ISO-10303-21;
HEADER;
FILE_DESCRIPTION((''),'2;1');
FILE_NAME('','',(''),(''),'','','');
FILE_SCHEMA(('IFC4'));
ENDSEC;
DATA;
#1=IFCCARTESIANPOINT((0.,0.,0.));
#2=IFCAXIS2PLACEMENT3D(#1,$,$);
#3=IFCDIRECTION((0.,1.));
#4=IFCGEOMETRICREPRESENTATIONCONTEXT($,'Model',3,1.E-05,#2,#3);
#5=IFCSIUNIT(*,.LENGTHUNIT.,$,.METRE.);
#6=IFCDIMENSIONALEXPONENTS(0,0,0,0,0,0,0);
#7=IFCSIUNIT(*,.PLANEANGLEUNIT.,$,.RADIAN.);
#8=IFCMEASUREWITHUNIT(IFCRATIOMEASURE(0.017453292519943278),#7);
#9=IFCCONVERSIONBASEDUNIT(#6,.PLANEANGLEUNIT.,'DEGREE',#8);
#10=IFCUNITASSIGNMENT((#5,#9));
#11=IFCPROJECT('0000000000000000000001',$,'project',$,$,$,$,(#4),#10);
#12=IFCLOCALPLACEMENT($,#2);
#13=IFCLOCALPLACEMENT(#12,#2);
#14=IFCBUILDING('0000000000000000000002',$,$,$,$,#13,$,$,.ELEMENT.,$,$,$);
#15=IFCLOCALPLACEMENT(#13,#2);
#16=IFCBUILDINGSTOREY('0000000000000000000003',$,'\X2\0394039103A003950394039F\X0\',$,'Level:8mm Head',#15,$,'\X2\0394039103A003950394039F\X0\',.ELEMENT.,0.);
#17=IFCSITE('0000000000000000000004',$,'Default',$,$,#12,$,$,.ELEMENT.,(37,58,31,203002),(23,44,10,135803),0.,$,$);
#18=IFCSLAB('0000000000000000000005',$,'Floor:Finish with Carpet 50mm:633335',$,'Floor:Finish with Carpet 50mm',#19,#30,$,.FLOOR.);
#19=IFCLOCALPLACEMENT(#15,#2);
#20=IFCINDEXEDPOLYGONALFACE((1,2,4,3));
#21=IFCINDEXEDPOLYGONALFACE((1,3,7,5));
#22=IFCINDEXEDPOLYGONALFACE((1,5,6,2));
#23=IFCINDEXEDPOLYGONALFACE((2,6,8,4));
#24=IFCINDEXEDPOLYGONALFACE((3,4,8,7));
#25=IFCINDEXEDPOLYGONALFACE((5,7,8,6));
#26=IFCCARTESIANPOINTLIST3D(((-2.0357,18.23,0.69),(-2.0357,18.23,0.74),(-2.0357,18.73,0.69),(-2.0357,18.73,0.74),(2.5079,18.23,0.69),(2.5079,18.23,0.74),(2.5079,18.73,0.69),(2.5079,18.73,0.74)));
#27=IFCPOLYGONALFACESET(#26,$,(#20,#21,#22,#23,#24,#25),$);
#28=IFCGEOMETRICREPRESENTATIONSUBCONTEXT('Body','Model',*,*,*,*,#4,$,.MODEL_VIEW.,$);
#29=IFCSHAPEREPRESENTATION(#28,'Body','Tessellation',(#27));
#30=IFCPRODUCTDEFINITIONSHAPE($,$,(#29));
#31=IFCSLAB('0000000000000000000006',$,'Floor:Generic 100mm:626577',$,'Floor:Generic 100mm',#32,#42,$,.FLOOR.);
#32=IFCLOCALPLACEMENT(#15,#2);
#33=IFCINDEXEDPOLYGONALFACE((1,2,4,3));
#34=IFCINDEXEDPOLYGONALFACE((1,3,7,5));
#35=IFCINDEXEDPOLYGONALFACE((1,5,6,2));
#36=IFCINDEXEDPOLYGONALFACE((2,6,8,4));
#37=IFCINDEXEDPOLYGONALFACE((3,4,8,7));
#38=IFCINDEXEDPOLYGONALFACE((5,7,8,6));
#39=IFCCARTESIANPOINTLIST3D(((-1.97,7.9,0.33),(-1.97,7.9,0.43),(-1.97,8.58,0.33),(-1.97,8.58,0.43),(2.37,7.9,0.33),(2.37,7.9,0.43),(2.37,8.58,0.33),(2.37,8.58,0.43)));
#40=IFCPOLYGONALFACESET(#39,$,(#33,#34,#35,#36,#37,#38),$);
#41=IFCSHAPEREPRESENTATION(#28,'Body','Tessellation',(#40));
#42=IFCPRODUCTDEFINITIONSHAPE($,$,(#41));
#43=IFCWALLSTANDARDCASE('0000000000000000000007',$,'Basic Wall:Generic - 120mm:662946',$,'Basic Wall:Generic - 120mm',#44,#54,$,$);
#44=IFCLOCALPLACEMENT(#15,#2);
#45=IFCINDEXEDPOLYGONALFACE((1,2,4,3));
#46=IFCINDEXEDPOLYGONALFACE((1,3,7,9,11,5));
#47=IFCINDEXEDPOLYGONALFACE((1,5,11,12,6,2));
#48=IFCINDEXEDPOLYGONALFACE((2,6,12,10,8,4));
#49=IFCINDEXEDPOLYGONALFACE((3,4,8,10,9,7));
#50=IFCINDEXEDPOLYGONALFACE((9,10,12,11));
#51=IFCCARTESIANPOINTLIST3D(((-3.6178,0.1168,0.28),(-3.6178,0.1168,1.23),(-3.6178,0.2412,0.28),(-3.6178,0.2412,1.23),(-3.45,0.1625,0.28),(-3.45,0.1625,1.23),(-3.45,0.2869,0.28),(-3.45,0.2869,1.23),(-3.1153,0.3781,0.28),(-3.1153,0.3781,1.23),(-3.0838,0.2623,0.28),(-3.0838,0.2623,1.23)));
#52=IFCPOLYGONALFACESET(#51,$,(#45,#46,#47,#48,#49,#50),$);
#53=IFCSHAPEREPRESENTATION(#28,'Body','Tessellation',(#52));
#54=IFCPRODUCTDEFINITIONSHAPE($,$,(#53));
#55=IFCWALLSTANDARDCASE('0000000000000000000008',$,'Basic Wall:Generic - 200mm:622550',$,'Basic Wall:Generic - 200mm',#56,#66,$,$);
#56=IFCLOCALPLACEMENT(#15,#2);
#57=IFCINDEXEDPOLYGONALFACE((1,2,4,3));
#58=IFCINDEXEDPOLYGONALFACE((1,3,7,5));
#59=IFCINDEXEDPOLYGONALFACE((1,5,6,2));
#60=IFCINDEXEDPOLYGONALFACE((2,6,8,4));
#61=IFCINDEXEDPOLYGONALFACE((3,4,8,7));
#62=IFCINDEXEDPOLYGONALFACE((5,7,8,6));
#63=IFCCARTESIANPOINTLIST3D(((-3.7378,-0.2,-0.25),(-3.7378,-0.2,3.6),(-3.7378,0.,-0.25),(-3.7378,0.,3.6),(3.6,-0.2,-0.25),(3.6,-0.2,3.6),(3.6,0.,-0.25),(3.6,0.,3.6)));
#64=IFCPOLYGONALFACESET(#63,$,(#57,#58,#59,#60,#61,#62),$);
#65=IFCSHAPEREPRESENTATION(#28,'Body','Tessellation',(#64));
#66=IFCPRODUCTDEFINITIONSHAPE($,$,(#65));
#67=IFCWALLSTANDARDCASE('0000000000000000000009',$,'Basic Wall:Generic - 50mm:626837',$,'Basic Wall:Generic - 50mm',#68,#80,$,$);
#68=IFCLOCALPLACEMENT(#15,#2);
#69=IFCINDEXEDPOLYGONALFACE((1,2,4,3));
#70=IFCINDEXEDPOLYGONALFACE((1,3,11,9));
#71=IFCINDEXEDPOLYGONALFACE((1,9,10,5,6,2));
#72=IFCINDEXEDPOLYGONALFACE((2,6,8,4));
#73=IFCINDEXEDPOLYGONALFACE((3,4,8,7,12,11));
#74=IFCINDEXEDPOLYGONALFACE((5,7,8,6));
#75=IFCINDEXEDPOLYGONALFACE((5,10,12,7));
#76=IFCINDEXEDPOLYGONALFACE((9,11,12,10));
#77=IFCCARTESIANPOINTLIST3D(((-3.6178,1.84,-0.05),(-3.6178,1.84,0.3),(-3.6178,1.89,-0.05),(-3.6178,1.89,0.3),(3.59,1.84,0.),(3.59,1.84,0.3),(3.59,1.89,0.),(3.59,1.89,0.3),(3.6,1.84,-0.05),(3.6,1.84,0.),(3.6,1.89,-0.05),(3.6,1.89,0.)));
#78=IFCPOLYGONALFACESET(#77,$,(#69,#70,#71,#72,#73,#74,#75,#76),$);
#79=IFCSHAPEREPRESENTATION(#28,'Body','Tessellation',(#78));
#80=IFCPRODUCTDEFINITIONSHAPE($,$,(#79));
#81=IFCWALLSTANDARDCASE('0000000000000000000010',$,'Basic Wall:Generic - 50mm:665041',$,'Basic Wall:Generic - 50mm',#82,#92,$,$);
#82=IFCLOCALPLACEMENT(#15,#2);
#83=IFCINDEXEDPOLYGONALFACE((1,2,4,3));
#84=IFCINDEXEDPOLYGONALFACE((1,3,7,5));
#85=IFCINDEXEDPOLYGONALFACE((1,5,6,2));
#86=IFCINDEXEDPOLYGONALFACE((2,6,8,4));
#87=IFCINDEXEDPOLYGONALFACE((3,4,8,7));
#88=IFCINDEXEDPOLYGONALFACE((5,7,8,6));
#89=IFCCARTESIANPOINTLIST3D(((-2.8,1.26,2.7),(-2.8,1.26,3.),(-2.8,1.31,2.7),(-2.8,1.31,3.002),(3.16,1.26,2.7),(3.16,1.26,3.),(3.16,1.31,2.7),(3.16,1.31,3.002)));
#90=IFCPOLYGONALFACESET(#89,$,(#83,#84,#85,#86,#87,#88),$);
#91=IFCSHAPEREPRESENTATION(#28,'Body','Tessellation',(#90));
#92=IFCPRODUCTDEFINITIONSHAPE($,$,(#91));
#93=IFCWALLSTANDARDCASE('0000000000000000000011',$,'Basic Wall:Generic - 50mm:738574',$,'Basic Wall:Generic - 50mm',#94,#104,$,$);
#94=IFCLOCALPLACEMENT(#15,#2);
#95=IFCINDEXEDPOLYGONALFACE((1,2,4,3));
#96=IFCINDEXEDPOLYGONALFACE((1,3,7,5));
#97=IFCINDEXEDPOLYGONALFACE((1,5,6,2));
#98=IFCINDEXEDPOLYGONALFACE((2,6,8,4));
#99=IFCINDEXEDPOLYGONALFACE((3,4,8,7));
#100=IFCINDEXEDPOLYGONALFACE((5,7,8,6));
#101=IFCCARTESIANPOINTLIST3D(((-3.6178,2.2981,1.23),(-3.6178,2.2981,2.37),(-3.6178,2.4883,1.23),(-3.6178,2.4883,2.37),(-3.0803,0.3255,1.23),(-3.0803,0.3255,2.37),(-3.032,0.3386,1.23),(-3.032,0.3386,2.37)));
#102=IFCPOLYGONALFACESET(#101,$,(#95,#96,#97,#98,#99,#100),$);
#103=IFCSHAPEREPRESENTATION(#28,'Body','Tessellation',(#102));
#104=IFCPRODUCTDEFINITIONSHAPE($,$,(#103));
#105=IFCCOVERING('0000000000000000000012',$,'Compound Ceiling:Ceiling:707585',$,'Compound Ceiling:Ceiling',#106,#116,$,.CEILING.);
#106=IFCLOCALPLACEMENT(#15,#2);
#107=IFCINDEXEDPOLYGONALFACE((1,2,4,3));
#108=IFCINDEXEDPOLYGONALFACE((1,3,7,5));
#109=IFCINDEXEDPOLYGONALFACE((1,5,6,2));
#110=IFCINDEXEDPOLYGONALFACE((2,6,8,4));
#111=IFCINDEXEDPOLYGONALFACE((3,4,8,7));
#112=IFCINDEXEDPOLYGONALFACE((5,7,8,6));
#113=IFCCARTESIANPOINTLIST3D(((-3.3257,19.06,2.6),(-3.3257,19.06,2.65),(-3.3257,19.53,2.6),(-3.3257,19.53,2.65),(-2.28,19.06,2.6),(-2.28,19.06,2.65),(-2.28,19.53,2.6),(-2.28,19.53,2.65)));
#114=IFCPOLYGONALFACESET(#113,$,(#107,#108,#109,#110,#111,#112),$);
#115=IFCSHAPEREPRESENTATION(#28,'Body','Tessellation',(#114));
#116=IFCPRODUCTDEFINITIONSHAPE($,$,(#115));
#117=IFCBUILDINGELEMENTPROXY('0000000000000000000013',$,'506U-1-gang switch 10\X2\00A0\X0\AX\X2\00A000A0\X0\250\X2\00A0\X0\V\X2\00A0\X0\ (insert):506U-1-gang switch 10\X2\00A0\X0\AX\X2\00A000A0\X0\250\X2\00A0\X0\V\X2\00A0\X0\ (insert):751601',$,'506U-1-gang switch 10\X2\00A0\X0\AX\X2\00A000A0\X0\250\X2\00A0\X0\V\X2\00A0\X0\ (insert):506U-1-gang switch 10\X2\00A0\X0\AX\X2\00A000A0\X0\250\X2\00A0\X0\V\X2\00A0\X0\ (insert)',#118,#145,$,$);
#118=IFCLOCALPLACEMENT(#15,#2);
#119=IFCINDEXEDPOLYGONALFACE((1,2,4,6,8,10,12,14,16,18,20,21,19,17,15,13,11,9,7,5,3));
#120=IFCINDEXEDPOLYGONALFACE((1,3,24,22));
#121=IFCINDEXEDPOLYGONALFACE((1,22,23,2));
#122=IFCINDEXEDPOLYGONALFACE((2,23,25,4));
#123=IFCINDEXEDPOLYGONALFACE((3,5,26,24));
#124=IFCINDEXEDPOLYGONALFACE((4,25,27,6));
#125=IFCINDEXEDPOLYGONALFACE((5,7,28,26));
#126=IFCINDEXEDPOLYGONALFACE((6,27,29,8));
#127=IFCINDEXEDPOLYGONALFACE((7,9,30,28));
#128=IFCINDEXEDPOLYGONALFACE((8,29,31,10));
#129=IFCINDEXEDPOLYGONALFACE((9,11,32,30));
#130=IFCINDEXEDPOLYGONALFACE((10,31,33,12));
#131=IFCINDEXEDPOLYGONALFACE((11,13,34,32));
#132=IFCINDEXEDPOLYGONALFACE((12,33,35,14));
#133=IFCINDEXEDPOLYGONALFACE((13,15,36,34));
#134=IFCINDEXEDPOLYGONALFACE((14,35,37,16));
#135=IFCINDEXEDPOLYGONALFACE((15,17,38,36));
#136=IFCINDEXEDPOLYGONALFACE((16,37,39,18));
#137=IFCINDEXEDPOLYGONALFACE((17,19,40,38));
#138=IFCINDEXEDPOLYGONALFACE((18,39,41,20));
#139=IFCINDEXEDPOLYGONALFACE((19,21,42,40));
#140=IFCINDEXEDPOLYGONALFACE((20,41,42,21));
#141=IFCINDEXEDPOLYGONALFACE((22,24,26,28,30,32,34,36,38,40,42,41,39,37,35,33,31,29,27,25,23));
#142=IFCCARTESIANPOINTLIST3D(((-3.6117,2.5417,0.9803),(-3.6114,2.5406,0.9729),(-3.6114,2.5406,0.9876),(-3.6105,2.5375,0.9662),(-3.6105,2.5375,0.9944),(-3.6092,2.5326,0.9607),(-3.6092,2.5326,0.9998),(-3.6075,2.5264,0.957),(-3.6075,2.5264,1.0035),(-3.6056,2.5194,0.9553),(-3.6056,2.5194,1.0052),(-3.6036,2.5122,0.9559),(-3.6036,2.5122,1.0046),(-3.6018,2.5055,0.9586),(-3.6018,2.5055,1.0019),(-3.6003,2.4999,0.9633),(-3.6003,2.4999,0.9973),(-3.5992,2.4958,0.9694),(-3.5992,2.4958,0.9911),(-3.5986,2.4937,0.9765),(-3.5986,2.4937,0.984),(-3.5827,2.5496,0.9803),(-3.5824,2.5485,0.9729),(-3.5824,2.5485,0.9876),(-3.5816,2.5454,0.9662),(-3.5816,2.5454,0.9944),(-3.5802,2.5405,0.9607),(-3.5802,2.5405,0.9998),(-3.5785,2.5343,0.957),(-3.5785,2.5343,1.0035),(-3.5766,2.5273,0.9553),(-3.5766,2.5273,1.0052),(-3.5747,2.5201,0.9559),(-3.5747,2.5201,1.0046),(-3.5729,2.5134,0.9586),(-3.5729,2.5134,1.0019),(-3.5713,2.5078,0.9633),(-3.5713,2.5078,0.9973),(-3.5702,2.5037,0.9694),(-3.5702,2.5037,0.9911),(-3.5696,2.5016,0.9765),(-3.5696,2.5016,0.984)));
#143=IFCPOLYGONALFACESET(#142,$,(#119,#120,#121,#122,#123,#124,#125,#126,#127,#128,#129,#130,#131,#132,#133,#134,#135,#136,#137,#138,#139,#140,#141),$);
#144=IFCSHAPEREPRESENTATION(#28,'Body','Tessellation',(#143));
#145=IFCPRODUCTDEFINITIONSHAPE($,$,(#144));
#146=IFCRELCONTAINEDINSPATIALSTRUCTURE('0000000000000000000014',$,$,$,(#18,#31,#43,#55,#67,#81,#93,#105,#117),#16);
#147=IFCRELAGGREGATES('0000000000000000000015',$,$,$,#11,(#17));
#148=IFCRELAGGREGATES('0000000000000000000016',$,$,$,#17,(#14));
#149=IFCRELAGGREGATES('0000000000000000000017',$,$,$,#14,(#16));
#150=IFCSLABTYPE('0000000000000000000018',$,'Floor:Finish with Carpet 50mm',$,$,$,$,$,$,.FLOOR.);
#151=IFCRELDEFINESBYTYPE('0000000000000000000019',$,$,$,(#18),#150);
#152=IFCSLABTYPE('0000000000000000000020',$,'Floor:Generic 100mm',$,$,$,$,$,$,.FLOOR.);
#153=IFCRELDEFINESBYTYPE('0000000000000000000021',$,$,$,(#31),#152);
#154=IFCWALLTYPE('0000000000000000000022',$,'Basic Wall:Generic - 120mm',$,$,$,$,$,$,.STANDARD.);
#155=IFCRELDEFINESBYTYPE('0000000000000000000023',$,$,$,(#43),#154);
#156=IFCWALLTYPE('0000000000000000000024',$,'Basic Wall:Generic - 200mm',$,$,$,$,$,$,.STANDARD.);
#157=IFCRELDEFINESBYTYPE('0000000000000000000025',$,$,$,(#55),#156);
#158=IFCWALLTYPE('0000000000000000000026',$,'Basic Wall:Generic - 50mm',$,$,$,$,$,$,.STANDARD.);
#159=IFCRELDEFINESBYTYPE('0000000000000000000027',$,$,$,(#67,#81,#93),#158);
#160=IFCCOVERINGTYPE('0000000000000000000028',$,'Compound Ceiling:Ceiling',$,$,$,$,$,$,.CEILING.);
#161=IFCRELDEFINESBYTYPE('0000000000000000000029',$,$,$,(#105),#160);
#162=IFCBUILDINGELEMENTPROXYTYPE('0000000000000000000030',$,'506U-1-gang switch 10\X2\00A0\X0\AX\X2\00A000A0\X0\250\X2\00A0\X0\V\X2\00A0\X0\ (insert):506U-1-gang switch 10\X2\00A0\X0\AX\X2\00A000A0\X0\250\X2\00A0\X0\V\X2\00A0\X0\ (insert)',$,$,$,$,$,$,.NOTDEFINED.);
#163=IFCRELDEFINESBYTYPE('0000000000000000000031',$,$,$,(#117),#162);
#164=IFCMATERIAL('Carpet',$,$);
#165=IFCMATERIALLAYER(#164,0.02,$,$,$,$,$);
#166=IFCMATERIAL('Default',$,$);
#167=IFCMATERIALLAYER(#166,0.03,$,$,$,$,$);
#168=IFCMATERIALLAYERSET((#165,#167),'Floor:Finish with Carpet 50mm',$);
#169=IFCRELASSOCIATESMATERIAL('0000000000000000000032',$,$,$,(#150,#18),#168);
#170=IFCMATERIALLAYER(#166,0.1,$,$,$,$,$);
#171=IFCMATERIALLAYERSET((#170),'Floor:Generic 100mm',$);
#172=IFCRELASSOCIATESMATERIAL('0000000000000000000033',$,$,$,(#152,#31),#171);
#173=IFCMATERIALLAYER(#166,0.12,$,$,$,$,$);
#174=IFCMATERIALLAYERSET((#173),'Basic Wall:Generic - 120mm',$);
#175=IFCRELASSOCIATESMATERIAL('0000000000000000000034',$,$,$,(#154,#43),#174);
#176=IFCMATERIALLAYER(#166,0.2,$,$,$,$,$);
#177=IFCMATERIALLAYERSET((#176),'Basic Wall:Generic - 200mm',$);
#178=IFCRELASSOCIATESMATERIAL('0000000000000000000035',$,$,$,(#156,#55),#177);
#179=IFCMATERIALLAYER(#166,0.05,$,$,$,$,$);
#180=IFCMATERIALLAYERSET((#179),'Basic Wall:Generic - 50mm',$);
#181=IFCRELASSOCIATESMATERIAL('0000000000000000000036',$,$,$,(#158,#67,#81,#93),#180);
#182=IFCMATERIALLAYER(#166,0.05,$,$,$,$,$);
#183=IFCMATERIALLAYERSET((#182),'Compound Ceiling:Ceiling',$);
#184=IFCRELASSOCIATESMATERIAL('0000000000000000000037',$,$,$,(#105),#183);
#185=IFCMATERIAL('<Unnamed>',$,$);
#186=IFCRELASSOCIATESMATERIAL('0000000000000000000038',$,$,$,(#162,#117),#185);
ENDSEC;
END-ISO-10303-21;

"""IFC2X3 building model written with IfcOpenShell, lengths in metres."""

from ifc_helpers import new_model, entity, si_unit, converted_unit, direction, frame, frame_2d, origin, place, context, subcontext, project, spatial, polyline, rectangle, circle, outline, extrude, clip, bounded_halfspace, source, transform, mapped, material, layer, layer_set, layer_usage, type_object, type_shapes, element, save


model = new_model("IFC2X3")

# Units and contexts
model_context = context("Model", 3, precision=1e-05, world=origin(), true_north=direction((0.0, 1.0)))
body_context = subcontext(model_context, "Body", "Model", "MODEL_VIEW")
ifc_project = project(units=[si_unit("LENGTHUNIT", "METRE"), converted_unit("PLANEANGLEUNIT", "DEGREE", entity("IfcRatioMeasure", 0.017453292519943278), si_unit("PLANEANGLEUNIT", "RADIAN"), dimensions=[0, 0, 0, 0, 0, 0, 0])], contexts=[model_context])

# Site, building, storey
site_placement = place(None, origin())
site = spatial("IfcSite", under=ifc_project, at=site_placement, Name="Default", CompositionType="ELEMENT", RefLatitude=(37, 58, 31, 203002), RefLongitude=(23, 44, 10, 135803), RefElevation=0.0)
building_placement = place(site_placement, origin())
building = spatial("IfcBuilding", under=site, at=building_placement, CompositionType="ELEMENT")
storey_placement = place(building_placement, origin())
storey = spatial("IfcBuildingStorey", under=building, at=storey_placement, Name="ΔΑΠΕΔΟ", ObjectType="Level:8mm Head", LongName="ΔΑΠΕΔΟ", CompositionType="ELEMENT", Elevation=0.0)

# Slabs
ifc_material_1 = material(Name="Carpet")
ifc_layer_1 = layer(ifc_material_1, 0.02)
ifc_material_2 = material(Name="Default")
ifc_layer_2 = layer(ifc_material_2, 0.03)
ifc_layer_set_1 = layer_set([ifc_layer_1, ifc_layer_2], Name="Floor:Finish with Carpet 50mm")
ifc_layer_usage_1 = layer_usage(ifc_layer_set_1, "AXIS3", "POSITIVE", 0.0)
slab_type_1 = type_object("IfcSlabType", Name="Floor:Finish with Carpet 50mm", PredefinedType="FLOOR", material=ifc_layer_set_1)
slab_1_placement = place(storey_placement, origin())
element("IfcSlab", 1, at=slab_1_placement, inside=storey, type_object=slab_type_1, material=ifc_layer_usage_1, Name="Floor:Finish with Carpet 50mm:633335", ObjectType="Floor:Finish with Carpet 50mm", PredefinedType="FLOOR", context=body_context, shape_type="SweptSolid", body=[
    extrude(rectangle(XDim=0.5, YDim=4.5435, at=frame_2d((0.0, 0.0), x_axis=(1.0, 0.0))), frame((0.2361, 18.48, 0.74), z_axis=(0.0, 0.0, -1.0), x_axis=(0.0, 1.0, 0.0)), (0.0, 0.0, 1.0), 0.05),
])
ifc_layer_3 = layer(ifc_material_2, 0.1)
ifc_layer_set_2 = layer_set([ifc_layer_3], Name="Floor:Generic 100mm")
ifc_layer_usage_2 = layer_usage(ifc_layer_set_2, "AXIS3", "POSITIVE", 0.0)
slab_type_2 = type_object("IfcSlabType", Name="Floor:Generic 100mm", PredefinedType="FLOOR", material=ifc_layer_set_2)
slab_2_placement = place(storey_placement, origin())
element("IfcSlab", 2, at=slab_2_placement, inside=storey, type_object=slab_type_2, material=ifc_layer_usage_2, Name="Floor:Generic 100mm:626577", ObjectType="Floor:Generic 100mm", PredefinedType="FLOOR", context=body_context, shape_type="SweptSolid", body=[
    extrude(rectangle(XDim=0.68, YDim=4.34, at=frame_2d((0.0, 0.0), x_axis=(1.0, 0.0))), frame((0.2, 8.24, 0.43), z_axis=(0.0, 0.0, -1.0), x_axis=(0.0, 1.0, 0.0)), (0.0, 0.0, 1.0), 0.1),
])

# Walls
ifc_layer_4 = layer(ifc_material_2, 0.12)
ifc_layer_set_3 = layer_set([ifc_layer_4], Name="Basic Wall:Generic - 120mm")
ifc_layer_usage_3 = layer_usage(ifc_layer_set_3, "AXIS2", "NEGATIVE", 0.06)
wall_type_1 = type_object("IfcWallType", Name="Basic Wall:Generic - 120mm", PredefinedType="STANDARD", material=ifc_layer_set_3)
wall_1_placement = place(storey_placement, frame((-3.0996, 0.3202, 0.28), z_axis=(0.0, 0.0, 1.0), x_axis=(-0.964815, -0.262929, 0.0)))
element("IfcWallStandardCase", 3, at=wall_1_placement, inside=storey, type_object=wall_type_1, material=ifc_layer_usage_3, Name="Basic Wall:Generic - 120mm:662946", ObjectType="Basic Wall:Generic - 120mm", context=body_context, shape_type="SweptSolid", body=[
    extrude(outline(polyline([(0.5208, -0.06), (0.5535, 0.06), (0.3796, 0.06), (0.0, 0.06), (0.0, -0.06), (0.3469, -0.06), (0.5208, -0.06)])), origin(), (0.0, 0.0, 1.0), 0.95),
])
ifc_layer_5 = layer(ifc_material_2, 0.2)
ifc_layer_set_4 = layer_set([ifc_layer_5], Name="Basic Wall:Generic - 200mm")
ifc_layer_usage_4 = layer_usage(ifc_layer_set_4, "AXIS2", "NEGATIVE", 0.1)
wall_type_2 = type_object("IfcWallType", Name="Basic Wall:Generic - 200mm", PredefinedType="STANDARD", material=ifc_layer_set_4)
wall_2_placement = place(storey_placement, frame((-3.7378, -0.1, -0.25)))
element("IfcWallStandardCase", 4, at=wall_2_placement, inside=storey, type_object=wall_type_2, material=ifc_layer_usage_4, Name="Basic Wall:Generic - 200mm:622550", ObjectType="Basic Wall:Generic - 200mm", context=body_context, shape_type="SweptSolid", body=[
    extrude(rectangle(XDim=7.3378, YDim=0.2, at=frame_2d((3.6689, 0.0), x_axis=(-1.0, 0.0))), origin(), (0.0, 0.0, 1.0), 3.85),
])
ifc_layer_6 = layer(ifc_material_2, 0.05)
ifc_layer_set_5 = layer_set([ifc_layer_6], Name="Basic Wall:Generic - 50mm")
ifc_layer_usage_5 = layer_usage(ifc_layer_set_5, "AXIS2", "NEGATIVE", 0.025)
wall_type_3 = type_object("IfcWallType", Name="Basic Wall:Generic - 50mm", PredefinedType="STANDARD", material=ifc_layer_set_5)
wall_3_placement = place(storey_placement, frame((-3.6178, 1.865, -0.05)))
element("IfcWallStandardCase", 5, at=wall_3_placement, inside=storey, type_object=wall_type_3, material=ifc_layer_usage_5, Name="Basic Wall:Generic - 50mm:626837", ObjectType="Basic Wall:Generic - 50mm", context=body_context, shape_type="Clipping", body=[
    clip(clip(extrude(rectangle(XDim=7.2178, YDim=0.05, at=frame_2d((3.6089, 0.0), x_axis=(-1.0, 0.0))), origin(), (0.0, 0.0, 1.0), 0.35), bounded_halfspace(frame((7.2078, -0.025, 0.05), z_axis=(-1.0, 0.0, 0.0), x_axis=(0.0, -1.0, 0.0)), True, frame((7.2078, -0.025, 0.05), z_axis=(-1.0, 0.0, 0.0), x_axis=(0.0, -1.0, 0.0)), polyline([(0.0, 0.0), (0.0, 0.25), (0.0, 0.3), (-0.05, 0.3), (-0.05, 0.1575), (-0.05, 0.1075), (-0.05, 0.0), (0.0, 0.0)]))), bounded_halfspace(frame((7.2078, 0.025, 0.05), z_axis=(0.0, 0.0, -1.0), x_axis=(-1.0, 0.0, 0.0)), True, frame((7.2078, 0.025, 0.05), z_axis=(0.0, 0.0, -1.0), x_axis=(-1.0, 0.0, 0.0)), polyline([(0.0, 0.0), (-0.01, 0.0), (-0.01, -0.05), (0.0, -0.05), (0.0, 0.0)]))),
])
wall_4_placement = place(storey_placement, frame((-2.8, 1.285, 2.7)))
element("IfcWallStandardCase", 6, at=wall_4_placement, inside=storey, type_object=wall_type_3, material=ifc_layer_usage_5, Name="Basic Wall:Generic - 50mm:665041", ObjectType="Basic Wall:Generic - 50mm", context=body_context, shape_type="Clipping", body=[
    clip(extrude(rectangle(XDim=5.96, YDim=0.05, at=frame_2d((2.98, 0.0), x_axis=(-1.0, 0.0))), origin(), (0.0, 0.0, 1.0), 0.302), bounded_halfspace(frame((0.0, -0.025, 0.3), z_axis=(0.0, 0.040782, -0.999168), x_axis=(0.0, 0.999168, 0.040782)), True, frame((0.0, -0.025, 0.3)), polyline([(0.0, 0.0), (5.91, 0.0), (5.96, 0.0), (5.96, 0.05), (5.91, 0.05), (0.05, 0.05), (0.0, 0.05), (0.0, 0.0)]))),
])
wall_5_placement = place(storey_placement, frame((-3.642, 2.4817, 1.23), z_axis=(0.0, 0.0, 1.0), x_axis=(0.262929, -0.964815, 0.0)))
element("IfcWallStandardCase", 7, at=wall_5_placement, inside=storey, type_object=wall_type_3, material=ifc_layer_usage_5, Name="Basic Wall:Generic - 50mm:738574", ObjectType="Basic Wall:Generic - 50mm", context=body_context, shape_type="SweptSolid", body=[
    extrude(outline(polyline([(2.2281, -0.025), (2.2281, 0.025), (0.0, 0.025), (0.1835, -0.025), (2.2281, -0.025)])), origin(), (0.0, 0.0, 1.0), 1.14),
])

# Covering
ifc_layer_7 = layer(ifc_material_2, 0.05)
ifc_layer_set_6 = layer_set([ifc_layer_7], Name="Compound Ceiling:Ceiling")
ifc_layer_usage_6 = layer_usage(ifc_layer_set_6, "AXIS3", "POSITIVE", 0.0)
covering_type = type_object("IfcCoveringType", Name="Compound Ceiling:Ceiling", PredefinedType="CEILING")
covering_1_placement = place(storey_placement, origin())
element("IfcCovering", 8, at=covering_1_placement, inside=storey, type_object=covering_type, material=ifc_layer_usage_6, Name="Compound Ceiling:Ceiling:707585", ObjectType="Compound Ceiling:Ceiling", PredefinedType="CEILING", context=body_context, shape_type="SweptSolid", body=[
    extrude(rectangle(XDim=1.0457, YDim=0.47, at=frame_2d((0.0, 0.0), x_axis=(1.0, 0.0))), frame((-2.8028, 19.295, 2.6)), (0.0, 0.0, 1.0), 0.05),
])

# Building element proxy
ifc_material_3 = material(Name="<Unnamed>")
building_element_proxy_type = type_object("IfcBuildingElementProxyType", Name="506U-1-gang switch 10 AX  250 V  (insert):506U-1-gang switch 10 AX  250 V  (insert)", PredefinedType="NOTDEFINED", material=ifc_material_3)
shared_shape = source(origin(), body_context, "Body", "SweptSolid", [
    extrude(circle(Radius=0.025, at=frame_2d((0.0, 0.0), x_axis=(1.0, 0.0))), origin(), (0.0, 0.0, 1.0), 0.03),
])
type_shapes(building_element_proxy_type, [shared_shape])
proxy_placement = place(storey_placement, frame((-3.6051, 2.5176, 0.9803), z_axis=(0.964815, 0.262929, 0.0), x_axis=(-0.262929, 0.964815, 0.0)))
element("IfcBuildingElementProxy", 9, at=proxy_placement, inside=storey, type_object=building_element_proxy_type, material=ifc_material_3, Name="506U-1-gang switch 10 AX  250 V  (insert):506U-1-gang switch 10 AX  250 V  (insert):751601", ObjectType="506U-1-gang switch 10 AX  250 V  (insert):506U-1-gang switch 10 AX  250 V  (insert)", context=body_context, shape_type="MappedRepresentation", body=[
    mapped(shared_shape, transform((0.0, 0.0, 0.0), scale=1.0)),
])

save(model, "model.ifc")
